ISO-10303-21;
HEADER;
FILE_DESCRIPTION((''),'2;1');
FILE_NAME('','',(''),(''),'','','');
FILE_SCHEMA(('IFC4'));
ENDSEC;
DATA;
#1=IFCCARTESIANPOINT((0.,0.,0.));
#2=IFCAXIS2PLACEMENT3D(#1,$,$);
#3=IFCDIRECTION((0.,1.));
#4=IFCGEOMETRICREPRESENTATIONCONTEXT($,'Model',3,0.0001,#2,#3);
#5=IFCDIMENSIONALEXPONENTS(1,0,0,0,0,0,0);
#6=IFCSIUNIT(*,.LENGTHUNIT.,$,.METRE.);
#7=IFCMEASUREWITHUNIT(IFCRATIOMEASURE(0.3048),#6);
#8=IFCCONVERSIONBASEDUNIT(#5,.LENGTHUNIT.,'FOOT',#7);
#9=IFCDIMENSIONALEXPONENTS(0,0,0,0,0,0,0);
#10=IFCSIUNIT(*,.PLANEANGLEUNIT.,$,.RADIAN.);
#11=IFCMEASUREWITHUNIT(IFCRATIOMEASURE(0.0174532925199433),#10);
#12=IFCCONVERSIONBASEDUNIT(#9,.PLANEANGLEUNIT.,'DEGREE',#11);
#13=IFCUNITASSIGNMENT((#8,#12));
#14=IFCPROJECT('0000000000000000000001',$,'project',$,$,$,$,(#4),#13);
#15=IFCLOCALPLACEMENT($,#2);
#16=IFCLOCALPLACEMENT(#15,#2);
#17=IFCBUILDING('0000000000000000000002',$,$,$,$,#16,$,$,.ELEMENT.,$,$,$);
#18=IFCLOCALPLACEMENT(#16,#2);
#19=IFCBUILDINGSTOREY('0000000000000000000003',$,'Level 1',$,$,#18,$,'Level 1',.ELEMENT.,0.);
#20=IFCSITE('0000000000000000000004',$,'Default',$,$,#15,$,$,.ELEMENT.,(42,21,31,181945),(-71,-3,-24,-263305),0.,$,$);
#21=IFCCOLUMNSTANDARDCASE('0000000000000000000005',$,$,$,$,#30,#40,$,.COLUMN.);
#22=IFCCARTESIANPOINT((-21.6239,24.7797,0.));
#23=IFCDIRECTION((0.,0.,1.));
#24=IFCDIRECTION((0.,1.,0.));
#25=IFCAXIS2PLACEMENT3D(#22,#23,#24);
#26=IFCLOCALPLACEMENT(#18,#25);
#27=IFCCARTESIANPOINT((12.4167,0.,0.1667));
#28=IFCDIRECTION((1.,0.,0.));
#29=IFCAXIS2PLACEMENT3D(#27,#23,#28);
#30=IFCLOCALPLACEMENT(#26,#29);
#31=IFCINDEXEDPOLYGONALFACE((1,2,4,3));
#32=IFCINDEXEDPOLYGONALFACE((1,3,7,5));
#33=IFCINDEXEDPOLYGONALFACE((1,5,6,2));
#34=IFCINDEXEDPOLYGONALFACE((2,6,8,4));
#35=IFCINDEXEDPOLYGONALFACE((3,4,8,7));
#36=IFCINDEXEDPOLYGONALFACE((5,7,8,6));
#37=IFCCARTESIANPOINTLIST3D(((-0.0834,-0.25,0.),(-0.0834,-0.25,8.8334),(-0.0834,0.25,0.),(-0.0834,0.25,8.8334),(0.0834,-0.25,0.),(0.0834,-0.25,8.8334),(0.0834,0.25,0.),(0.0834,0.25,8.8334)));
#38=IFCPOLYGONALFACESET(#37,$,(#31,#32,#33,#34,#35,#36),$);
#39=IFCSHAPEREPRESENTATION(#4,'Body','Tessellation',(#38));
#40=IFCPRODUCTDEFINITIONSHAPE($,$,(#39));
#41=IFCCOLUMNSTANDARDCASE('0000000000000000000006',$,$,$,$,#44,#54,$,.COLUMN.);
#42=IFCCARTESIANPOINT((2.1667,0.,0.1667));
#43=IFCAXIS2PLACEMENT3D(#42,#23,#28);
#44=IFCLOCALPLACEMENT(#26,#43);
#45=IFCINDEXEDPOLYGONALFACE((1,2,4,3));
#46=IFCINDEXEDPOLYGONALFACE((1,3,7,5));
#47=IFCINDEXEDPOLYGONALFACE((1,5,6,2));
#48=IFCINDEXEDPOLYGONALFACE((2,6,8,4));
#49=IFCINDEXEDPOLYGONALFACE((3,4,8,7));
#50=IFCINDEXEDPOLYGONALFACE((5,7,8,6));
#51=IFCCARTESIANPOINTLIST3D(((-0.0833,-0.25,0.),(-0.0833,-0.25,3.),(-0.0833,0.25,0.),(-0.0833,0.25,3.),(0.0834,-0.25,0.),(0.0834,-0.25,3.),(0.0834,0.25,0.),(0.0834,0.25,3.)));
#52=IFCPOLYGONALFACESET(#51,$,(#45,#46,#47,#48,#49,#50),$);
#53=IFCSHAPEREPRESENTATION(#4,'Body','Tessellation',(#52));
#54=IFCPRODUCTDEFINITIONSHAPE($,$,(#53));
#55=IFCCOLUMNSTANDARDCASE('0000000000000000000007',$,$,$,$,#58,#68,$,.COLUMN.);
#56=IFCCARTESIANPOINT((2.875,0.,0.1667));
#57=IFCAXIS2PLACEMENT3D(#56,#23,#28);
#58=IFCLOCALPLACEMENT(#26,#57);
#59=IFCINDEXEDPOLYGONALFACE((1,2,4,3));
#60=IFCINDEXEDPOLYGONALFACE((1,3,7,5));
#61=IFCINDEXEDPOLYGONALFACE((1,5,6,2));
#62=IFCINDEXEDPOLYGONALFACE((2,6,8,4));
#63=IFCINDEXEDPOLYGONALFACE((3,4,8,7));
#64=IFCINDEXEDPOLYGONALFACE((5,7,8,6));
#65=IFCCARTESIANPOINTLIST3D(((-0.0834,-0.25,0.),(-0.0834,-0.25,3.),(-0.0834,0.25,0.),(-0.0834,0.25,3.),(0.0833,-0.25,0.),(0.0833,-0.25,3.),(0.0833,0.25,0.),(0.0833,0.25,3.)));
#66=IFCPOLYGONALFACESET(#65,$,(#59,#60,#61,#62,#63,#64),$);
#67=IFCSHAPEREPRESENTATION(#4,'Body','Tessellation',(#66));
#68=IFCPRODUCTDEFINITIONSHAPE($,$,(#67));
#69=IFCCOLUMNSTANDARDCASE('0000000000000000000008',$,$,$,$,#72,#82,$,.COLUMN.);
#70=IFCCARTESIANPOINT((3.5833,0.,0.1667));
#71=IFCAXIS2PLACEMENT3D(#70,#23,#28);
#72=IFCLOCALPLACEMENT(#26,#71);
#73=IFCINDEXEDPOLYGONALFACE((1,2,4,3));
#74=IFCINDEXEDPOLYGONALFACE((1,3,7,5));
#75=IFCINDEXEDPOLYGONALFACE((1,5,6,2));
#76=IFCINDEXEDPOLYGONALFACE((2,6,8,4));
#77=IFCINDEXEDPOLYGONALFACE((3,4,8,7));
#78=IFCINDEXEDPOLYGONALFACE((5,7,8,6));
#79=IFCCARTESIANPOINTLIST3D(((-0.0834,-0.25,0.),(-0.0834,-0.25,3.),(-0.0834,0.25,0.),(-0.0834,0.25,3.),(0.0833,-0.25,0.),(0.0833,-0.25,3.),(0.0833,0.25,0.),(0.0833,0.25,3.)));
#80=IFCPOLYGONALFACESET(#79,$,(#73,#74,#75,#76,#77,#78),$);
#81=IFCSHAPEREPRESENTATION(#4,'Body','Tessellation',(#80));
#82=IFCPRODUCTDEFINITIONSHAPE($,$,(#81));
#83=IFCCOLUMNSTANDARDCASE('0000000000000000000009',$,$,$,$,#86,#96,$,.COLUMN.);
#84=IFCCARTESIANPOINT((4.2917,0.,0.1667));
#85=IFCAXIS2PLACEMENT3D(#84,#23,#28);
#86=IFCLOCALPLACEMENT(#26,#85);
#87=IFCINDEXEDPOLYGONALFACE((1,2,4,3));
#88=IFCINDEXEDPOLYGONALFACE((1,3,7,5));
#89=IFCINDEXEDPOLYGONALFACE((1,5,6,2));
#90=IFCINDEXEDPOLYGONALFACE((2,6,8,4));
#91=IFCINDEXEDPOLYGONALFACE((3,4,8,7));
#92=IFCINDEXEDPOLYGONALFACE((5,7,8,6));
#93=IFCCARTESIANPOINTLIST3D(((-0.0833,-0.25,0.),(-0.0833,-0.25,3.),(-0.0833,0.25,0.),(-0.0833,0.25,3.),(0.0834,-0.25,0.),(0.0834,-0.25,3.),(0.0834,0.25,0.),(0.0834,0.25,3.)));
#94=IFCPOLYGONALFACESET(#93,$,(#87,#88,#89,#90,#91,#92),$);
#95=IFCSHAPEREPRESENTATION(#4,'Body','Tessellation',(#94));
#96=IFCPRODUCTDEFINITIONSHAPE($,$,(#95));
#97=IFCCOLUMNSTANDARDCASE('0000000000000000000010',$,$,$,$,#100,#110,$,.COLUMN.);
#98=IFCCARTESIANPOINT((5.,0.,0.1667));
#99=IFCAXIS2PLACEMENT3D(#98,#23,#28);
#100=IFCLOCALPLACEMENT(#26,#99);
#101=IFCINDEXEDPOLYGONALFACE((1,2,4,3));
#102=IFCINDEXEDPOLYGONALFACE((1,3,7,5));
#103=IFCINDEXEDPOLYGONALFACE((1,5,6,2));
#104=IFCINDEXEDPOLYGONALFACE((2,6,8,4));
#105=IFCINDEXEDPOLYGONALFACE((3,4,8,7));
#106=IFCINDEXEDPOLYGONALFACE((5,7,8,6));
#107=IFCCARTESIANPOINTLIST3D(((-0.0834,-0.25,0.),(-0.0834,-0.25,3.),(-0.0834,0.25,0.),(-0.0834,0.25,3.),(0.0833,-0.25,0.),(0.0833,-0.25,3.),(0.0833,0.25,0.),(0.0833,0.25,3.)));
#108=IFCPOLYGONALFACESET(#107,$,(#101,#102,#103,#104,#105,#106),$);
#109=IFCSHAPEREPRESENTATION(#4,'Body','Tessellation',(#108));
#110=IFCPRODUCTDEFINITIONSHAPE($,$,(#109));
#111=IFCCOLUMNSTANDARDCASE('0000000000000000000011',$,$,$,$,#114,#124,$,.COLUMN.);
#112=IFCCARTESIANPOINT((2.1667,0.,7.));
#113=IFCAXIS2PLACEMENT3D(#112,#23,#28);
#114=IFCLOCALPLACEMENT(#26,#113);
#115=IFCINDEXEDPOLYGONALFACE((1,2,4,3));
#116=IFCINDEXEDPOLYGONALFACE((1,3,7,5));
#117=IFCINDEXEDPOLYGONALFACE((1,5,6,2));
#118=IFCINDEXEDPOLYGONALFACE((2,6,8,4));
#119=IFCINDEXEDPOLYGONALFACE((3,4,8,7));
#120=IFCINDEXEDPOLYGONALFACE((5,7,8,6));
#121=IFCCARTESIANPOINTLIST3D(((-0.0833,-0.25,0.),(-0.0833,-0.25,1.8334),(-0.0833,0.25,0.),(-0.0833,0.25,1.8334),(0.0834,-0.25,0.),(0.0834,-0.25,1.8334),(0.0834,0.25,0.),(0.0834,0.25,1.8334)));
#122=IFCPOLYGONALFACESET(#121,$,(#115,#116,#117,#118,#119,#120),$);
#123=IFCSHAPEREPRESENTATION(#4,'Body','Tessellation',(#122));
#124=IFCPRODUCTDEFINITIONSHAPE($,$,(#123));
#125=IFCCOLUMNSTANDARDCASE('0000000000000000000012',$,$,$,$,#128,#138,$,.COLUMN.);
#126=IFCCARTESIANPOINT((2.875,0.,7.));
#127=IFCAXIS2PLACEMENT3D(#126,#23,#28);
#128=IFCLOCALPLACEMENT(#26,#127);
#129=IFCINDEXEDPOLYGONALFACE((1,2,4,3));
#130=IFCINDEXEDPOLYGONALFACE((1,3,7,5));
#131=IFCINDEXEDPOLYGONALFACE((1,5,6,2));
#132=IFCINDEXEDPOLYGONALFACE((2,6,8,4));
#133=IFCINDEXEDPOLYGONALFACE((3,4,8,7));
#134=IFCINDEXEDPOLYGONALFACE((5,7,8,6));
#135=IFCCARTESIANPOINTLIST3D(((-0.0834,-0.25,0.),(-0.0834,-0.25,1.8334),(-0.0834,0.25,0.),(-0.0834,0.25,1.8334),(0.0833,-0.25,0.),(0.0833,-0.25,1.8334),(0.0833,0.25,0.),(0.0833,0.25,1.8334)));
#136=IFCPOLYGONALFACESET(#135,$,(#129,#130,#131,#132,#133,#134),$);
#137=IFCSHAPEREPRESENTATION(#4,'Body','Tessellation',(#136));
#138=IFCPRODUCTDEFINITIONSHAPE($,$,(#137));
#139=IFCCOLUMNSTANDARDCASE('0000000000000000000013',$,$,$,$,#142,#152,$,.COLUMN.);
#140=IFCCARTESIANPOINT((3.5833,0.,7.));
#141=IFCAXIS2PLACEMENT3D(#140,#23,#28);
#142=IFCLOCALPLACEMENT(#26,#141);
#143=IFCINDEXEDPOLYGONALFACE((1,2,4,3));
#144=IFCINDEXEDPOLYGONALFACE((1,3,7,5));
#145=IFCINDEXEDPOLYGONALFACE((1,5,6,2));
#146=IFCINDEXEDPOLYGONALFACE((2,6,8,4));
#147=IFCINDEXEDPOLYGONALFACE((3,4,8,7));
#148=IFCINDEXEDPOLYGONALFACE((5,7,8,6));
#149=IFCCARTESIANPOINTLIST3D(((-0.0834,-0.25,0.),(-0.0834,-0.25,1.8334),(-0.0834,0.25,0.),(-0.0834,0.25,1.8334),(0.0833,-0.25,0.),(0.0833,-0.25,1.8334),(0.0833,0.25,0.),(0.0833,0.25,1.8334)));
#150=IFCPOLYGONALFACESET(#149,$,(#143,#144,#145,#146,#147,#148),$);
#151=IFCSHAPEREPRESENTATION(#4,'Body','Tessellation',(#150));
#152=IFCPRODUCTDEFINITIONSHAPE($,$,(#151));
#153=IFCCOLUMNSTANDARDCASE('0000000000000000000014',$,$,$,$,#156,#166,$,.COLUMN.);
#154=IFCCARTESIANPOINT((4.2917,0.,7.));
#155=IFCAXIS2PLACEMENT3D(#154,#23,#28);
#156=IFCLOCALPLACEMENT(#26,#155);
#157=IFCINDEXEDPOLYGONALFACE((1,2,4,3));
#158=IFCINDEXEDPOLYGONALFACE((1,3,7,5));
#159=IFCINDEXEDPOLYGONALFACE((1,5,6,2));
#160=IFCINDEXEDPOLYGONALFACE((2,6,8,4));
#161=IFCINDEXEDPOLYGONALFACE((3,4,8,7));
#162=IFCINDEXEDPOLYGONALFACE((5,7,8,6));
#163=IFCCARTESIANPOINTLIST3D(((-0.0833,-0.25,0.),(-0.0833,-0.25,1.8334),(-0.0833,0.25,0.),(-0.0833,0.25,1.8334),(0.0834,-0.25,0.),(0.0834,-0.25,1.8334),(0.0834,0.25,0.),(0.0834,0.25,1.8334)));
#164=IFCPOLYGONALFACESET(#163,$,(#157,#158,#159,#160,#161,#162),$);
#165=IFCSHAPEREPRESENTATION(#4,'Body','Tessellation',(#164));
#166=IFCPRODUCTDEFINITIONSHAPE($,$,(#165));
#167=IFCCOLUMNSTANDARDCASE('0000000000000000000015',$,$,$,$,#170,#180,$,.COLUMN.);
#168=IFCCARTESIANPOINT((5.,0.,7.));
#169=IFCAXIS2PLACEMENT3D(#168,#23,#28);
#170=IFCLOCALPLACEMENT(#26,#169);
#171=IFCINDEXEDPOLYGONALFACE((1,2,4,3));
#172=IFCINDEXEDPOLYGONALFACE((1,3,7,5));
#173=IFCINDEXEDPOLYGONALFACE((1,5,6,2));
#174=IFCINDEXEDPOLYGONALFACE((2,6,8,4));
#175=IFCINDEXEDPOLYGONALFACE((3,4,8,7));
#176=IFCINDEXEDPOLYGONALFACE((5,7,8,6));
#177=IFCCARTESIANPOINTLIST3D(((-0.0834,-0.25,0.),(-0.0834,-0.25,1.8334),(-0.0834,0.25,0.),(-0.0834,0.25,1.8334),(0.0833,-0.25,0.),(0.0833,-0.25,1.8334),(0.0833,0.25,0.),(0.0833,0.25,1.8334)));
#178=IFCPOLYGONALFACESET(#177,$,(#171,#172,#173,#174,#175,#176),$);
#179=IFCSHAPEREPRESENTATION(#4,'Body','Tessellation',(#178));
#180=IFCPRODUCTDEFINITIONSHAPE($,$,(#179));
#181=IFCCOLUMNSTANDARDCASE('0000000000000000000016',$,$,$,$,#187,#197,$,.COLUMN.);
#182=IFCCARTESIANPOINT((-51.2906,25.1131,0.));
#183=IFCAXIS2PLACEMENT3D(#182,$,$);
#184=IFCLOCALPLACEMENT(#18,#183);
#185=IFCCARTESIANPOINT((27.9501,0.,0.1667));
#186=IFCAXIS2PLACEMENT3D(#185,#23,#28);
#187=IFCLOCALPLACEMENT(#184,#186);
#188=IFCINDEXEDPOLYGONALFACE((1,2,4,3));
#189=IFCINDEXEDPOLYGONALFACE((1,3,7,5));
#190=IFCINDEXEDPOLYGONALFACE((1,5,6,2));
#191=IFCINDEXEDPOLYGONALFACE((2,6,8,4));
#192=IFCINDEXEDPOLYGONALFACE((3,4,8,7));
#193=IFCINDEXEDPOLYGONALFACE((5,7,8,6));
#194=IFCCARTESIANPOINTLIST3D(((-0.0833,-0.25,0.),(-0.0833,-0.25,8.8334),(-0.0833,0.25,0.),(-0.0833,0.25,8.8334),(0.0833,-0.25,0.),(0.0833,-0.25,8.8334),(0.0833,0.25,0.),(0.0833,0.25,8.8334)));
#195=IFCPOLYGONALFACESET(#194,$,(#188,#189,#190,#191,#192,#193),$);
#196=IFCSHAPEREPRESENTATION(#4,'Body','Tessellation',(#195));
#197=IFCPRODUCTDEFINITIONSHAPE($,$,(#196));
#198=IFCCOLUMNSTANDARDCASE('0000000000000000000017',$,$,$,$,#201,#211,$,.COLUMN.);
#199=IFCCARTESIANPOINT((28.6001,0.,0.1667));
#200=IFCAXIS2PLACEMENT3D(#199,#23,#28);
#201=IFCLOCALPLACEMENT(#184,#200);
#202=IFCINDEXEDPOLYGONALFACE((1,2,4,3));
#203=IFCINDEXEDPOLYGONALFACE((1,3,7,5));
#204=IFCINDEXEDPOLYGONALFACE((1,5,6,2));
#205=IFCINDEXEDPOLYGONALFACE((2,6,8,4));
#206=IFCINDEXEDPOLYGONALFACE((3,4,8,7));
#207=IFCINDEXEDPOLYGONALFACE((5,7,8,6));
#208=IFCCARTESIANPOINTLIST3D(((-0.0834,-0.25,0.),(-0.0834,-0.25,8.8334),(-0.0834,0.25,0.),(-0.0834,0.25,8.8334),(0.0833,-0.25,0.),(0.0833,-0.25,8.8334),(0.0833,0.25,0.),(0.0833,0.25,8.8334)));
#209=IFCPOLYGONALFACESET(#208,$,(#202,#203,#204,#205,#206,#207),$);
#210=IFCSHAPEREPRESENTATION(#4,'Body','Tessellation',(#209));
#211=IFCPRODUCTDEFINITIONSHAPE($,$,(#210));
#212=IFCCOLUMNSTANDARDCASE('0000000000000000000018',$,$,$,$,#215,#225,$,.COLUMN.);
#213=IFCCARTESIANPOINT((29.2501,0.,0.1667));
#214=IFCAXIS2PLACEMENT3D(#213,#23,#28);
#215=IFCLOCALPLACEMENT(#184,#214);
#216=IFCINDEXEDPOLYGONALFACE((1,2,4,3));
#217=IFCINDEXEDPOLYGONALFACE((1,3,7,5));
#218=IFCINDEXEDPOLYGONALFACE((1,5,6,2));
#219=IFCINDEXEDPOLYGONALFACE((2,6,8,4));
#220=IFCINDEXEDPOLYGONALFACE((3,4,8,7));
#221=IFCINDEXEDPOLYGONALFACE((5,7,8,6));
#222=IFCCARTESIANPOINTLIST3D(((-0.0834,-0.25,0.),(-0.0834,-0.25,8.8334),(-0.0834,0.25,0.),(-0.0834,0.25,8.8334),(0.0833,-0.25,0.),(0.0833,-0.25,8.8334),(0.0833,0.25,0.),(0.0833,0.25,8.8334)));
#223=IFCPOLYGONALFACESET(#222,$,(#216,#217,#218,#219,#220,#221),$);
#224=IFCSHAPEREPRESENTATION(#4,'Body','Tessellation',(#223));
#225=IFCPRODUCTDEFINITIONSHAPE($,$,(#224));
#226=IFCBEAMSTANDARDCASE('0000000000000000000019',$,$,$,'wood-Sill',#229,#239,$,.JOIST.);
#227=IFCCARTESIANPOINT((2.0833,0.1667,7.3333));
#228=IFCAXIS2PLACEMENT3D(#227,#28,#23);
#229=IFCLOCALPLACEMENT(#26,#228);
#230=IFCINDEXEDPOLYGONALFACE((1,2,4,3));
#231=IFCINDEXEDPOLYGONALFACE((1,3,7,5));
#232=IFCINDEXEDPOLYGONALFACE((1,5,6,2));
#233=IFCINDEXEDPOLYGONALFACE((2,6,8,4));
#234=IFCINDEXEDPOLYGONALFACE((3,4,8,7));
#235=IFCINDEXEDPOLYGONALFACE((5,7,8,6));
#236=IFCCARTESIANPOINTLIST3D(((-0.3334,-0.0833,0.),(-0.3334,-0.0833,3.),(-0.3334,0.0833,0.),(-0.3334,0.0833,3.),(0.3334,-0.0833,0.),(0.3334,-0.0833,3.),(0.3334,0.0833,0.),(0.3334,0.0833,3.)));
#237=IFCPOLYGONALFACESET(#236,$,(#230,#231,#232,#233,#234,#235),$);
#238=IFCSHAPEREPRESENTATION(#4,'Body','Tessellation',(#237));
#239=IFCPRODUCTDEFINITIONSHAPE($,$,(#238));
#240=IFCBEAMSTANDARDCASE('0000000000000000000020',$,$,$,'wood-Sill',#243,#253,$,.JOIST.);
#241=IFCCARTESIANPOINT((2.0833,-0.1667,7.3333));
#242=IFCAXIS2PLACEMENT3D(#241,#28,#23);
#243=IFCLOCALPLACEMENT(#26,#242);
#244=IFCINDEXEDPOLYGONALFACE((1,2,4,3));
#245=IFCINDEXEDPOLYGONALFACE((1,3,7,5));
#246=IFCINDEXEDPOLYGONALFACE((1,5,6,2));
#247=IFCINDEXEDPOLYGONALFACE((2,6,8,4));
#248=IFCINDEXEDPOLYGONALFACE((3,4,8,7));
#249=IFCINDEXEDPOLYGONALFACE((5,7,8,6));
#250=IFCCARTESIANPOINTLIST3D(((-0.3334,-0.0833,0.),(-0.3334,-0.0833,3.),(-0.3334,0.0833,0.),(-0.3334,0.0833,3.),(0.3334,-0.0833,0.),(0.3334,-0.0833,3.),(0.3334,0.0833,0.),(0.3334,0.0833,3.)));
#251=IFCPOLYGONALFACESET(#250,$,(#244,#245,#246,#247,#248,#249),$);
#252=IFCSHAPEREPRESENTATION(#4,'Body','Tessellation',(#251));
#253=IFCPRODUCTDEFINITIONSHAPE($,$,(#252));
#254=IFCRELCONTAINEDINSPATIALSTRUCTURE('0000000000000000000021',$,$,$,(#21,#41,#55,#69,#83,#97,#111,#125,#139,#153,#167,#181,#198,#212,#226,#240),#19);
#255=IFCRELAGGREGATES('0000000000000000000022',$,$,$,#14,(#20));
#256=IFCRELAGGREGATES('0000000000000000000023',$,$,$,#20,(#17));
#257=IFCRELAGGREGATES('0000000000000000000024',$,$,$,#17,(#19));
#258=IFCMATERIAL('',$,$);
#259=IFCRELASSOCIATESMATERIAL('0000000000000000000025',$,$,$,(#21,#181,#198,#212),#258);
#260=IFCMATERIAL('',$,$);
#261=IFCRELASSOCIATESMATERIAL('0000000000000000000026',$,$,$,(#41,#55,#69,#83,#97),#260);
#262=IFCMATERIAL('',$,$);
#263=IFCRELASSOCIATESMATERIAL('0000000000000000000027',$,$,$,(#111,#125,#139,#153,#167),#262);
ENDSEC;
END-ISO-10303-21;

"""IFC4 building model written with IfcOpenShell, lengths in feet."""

from ifc_helpers import new_model, entity, si_unit, converted_unit, direction, frame, origin, origin_with_axes, place, context, project, spatial, rectangle, extrude, material, element, save


model = new_model("IFC4")

# Units and contexts
model_context = context("Model", 3, precision=0.0001, world=origin(), true_north=direction((0.0, 1.0)))
ifc_project = project(units=[converted_unit("LENGTHUNIT", "FOOT", entity("IfcRatioMeasure", 0.3048), si_unit("LENGTHUNIT", "METRE"), dimensions=[1, 0, 0, 0, 0, 0, 0]), converted_unit("PLANEANGLEUNIT", "DEGREE", entity("IfcRatioMeasure", 0.0174532925199433), si_unit("PLANEANGLEUNIT", "RADIAN"), dimensions=[0, 0, 0, 0, 0, 0, 0])], contexts=[model_context])

# Site, building, storey
site_placement = place(None, origin())
site = spatial("IfcSite", under=ifc_project, at=site_placement, Name="Default", CompositionType="ELEMENT", RefLatitude=(42, 21, 31, 181945), RefLongitude=(-71, -3, -24, -263305), RefElevation=0.0)
building_placement = place(site_placement, origin())
building = spatial("IfcBuilding", under=site, at=building_placement, CompositionType="ELEMENT")
storey_placement = place(building_placement, origin())
storey = spatial("IfcBuildingStorey", under=building, at=storey_placement, Name="Level 1", LongName="Level 1", CompositionType="ELEMENT", Elevation=0.0)

# Columns
placement_1 = place(storey_placement, frame((-21.6239, 24.7797, 0.0), z_axis=(0.0, 0.0, 1.0), x_axis=(0.0, 1.0, 0.0)))
ifc_material_1 = material(Name="")
for number, where, z_axis, x_axis in (
    (1, (12.4167, 0.0, 0.1667), (0.0, 0.0, 1.0), (1.0, 0.0, 0.0)),
):
    element("IfcColumnStandardCase", number, at=place(placement_1, frame(where, z_axis=z_axis, x_axis=x_axis)), inside=storey, material=ifc_material_1, PredefinedType="COLUMN", context=model_context, shape_type="SweptSolid", body=[
        extrude(rectangle(XDim=0.1667, YDim=0.5), origin(), (0.0, 0.0, 1.0), 8.8334),
    ])
ifc_material_2 = material(Name="")
for number, where, z_axis, x_axis in (
    (2, (2.1667, 0.0, 0.1667), (0.0, 0.0, 1.0), (1.0, 0.0, 0.0)),
    (3, (2.875, 0.0, 0.1667), (0.0, 0.0, 1.0), (1.0, 0.0, 0.0)),
    (4, (3.5833, 0.0, 0.1667), (0.0, 0.0, 1.0), (1.0, 0.0, 0.0)),
    (5, (4.2917, 0.0, 0.1667), (0.0, 0.0, 1.0), (1.0, 0.0, 0.0)),
    (6, (5.0, 0.0, 0.1667), (0.0, 0.0, 1.0), (1.0, 0.0, 0.0)),
):
    element("IfcColumnStandardCase", number, at=place(placement_1, frame(where, z_axis=z_axis, x_axis=x_axis)), inside=storey, material=ifc_material_2, PredefinedType="COLUMN", context=model_context, shape_type="SweptSolid", body=[
        extrude(rectangle(XDim=0.1667, YDim=0.5), origin(), (0.0, 0.0, 1.0), 3.0),
    ])
ifc_material_3 = material(Name="")
for number, where, z_axis, x_axis in (
    (7, (2.1667, 0.0, 7.0), (0.0, 0.0, 1.0), (1.0, 0.0, 0.0)),
    (8, (2.875, 0.0, 7.0), (0.0, 0.0, 1.0), (1.0, 0.0, 0.0)),
    (9, (3.5833, 0.0, 7.0), (0.0, 0.0, 1.0), (1.0, 0.0, 0.0)),
    (10, (4.2917, 0.0, 7.0), (0.0, 0.0, 1.0), (1.0, 0.0, 0.0)),
    (11, (5.0, 0.0, 7.0), (0.0, 0.0, 1.0), (1.0, 0.0, 0.0)),
):
    element("IfcColumnStandardCase", number, at=place(placement_1, frame(where, z_axis=z_axis, x_axis=x_axis)), inside=storey, material=ifc_material_3, PredefinedType="COLUMN", context=model_context, shape_type="SweptSolid", body=[
        extrude(rectangle(XDim=0.1667, YDim=0.5), origin(), (0.0, 0.0, 1.0), 1.8334),
    ])
placement_2 = place(storey_placement, frame((-51.2906, 25.1131, 0.0)))
for number, where, z_axis, x_axis in (
    (12, (27.9501, 0.0, 0.1667), (0.0, 0.0, 1.0), (1.0, 0.0, 0.0)),
    (13, (28.6001, 0.0, 0.1667), (0.0, 0.0, 1.0), (1.0, 0.0, 0.0)),
    (14, (29.2501, 0.0, 0.1667), (0.0, 0.0, 1.0), (1.0, 0.0, 0.0)),
):
    element("IfcColumnStandardCase", number, at=place(placement_2, frame(where, z_axis=z_axis, x_axis=x_axis)), inside=storey, material=ifc_material_1, PredefinedType="COLUMN", context=model_context, shape_type="SweptSolid", body=[
        extrude(rectangle(XDim=0.1667, YDim=0.5), origin(), (0.0, 0.0, 1.0), 8.8334),
    ])

# Beams
for number, where, z_axis, x_axis in (
    (15, (2.0833, 0.1667, 7.3333), (1.0, 0.0, 0.0), (0.0, 0.0, 1.0)),
    (16, (2.0833, -0.1667, 7.3333), (1.0, 0.0, 0.0), (0.0, 0.0, 1.0)),
):
    element("IfcBeamStandardCase", number, at=place(placement_1, frame(where, z_axis=z_axis, x_axis=x_axis)), inside=storey, ObjectType="wood-Sill", PredefinedType="JOIST", context=model_context, shape_type="SweptSolid", body=[
        extrude(rectangle(XDim=0.6667, YDim=0.1667), origin_with_axes(), (0.0, 0.0, 1.0), 3.0),
    ])

save(model, "model.ifc")
